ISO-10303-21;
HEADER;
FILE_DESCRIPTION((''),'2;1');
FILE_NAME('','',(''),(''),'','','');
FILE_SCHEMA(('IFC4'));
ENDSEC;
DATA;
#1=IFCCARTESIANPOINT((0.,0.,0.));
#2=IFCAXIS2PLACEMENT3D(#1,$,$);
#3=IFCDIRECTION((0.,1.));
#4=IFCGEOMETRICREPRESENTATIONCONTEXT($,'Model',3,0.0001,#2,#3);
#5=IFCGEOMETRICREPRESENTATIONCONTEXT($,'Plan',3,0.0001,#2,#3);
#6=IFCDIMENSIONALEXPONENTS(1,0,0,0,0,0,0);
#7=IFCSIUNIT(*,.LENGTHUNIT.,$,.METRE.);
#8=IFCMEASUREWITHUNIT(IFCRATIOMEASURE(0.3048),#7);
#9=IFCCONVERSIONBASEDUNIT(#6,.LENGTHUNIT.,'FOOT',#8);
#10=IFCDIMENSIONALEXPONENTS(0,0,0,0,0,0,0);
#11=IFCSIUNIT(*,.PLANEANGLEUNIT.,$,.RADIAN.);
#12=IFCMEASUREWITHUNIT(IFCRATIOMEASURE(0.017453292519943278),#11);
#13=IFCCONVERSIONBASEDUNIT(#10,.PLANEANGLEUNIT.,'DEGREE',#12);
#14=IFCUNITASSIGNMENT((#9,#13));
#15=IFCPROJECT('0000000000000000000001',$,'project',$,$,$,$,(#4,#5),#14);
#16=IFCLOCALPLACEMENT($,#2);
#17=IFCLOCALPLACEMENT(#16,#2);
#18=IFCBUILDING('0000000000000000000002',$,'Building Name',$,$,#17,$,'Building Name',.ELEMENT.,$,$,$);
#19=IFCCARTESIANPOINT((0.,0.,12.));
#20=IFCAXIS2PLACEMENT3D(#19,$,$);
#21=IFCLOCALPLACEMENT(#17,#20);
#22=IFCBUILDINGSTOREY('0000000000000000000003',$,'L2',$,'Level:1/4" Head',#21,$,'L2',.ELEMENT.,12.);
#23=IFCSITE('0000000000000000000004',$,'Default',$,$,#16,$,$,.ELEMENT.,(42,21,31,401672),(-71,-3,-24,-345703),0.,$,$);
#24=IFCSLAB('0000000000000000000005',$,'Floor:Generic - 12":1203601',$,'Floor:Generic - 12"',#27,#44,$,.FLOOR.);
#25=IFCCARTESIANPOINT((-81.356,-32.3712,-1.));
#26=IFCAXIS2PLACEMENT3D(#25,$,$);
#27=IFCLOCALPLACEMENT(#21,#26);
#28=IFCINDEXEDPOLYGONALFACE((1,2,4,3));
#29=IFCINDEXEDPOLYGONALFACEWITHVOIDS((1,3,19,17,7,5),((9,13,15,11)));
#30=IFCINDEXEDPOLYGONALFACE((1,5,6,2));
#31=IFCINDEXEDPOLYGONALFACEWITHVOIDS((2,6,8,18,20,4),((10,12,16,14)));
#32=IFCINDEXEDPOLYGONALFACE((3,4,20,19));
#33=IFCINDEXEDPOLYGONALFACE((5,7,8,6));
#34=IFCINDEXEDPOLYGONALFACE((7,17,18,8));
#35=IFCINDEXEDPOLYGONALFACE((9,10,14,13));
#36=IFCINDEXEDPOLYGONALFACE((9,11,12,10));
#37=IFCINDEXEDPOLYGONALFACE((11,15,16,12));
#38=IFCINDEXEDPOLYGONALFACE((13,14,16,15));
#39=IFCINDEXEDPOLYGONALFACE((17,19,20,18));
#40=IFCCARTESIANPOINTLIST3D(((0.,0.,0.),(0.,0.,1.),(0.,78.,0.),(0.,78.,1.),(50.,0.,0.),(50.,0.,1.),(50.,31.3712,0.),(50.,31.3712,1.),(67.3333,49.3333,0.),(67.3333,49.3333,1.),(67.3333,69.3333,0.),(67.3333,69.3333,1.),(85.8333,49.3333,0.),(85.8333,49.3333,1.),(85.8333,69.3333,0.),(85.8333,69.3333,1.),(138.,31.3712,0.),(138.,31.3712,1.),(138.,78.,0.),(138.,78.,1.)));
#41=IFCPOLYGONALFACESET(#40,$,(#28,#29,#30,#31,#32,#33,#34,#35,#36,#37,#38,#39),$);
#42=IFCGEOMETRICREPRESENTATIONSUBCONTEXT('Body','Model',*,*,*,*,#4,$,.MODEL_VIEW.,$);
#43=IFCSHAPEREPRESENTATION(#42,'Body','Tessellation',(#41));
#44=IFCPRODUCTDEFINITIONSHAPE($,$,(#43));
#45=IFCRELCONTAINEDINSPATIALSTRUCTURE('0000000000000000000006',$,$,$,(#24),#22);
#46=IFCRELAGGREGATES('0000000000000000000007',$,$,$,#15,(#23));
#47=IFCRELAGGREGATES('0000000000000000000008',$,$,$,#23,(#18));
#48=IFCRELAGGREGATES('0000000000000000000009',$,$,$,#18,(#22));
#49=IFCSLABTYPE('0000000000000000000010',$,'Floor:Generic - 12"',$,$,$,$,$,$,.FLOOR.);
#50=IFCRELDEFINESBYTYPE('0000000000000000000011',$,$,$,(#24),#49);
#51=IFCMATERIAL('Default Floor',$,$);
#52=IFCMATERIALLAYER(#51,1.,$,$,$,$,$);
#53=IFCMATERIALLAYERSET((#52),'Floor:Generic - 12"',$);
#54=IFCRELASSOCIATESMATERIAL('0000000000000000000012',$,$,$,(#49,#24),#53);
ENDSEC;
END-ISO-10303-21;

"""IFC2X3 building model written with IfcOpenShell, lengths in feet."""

from ifc_helpers import new_model, entity, si_unit, converted_unit, direction, frame, frame_2d, origin, place, context, subcontext, project, spatial, polyline, rectangle, outline, extrude, material, layer, layer_set, layer_usage, type_object, element, save


model = new_model("IFC2X3")

# Units and contexts
model_context = context("Model", 3, precision=0.0001, world=origin(), true_north=direction((0.0, 1.0)))
plan_context = context("Plan", 3, precision=0.0001, world=origin(), true_north=direction((0.0, 1.0)))
body_context = subcontext(model_context, "Body", "Model", "MODEL_VIEW")
ifc_project = project(units=[converted_unit("LENGTHUNIT", "FOOT", entity("IfcRatioMeasure", 0.3048), si_unit("LENGTHUNIT", "METRE"), dimensions=[1, 0, 0, 0, 0, 0, 0]), converted_unit("PLANEANGLEUNIT", "DEGREE", entity("IfcRatioMeasure", 0.017453292519943278), si_unit("PLANEANGLEUNIT", "RADIAN"), dimensions=[0, 0, 0, 0, 0, 0, 0])], contexts=[model_context, plan_context])

# Site, building, storey
site_placement = place(None, origin())
site = spatial("IfcSite", under=ifc_project, at=site_placement, Name="Default", CompositionType="ELEMENT", RefLatitude=(42, 21, 31, 401672), RefLongitude=(-71, -3, -24, -345703), RefElevation=0.0)
building_placement = place(site_placement, origin())
building = spatial("IfcBuilding", under=site, at=building_placement, Name="Building Name", LongName="Building Name", CompositionType="ELEMENT")
storey_placement = place(building_placement, frame((0.0, 0.0, 12.0)))
storey = spatial("IfcBuildingStorey", under=building, at=storey_placement, Name="L2", ObjectType="Level:1/4\" Head", LongName="L2", CompositionType="ELEMENT", Elevation=12.0)

# Slab, opening
ifc_material_1 = material(Name="Default Floor")
ifc_layer_1 = layer(ifc_material_1, 1.0)
ifc_layer_set_1 = layer_set([ifc_layer_1], Name="Floor:Generic - 12\"")
ifc_layer_usage_1 = layer_usage(ifc_layer_set_1, "AXIS3", "POSITIVE", 0.0)
slab_type_1 = type_object("IfcSlabType", Name="Floor:Generic - 12\"", PredefinedType="FLOOR", material=ifc_layer_set_1)
slab_1_placement = place(storey_placement, frame((-81.356, -32.3712, -1.0)))
slab_1 = element("IfcSlab", 1, at=slab_1_placement, inside=storey, type_object=slab_type_1, material=ifc_layer_usage_1, Name="Floor:Generic - 12\":1203601", ObjectType="Floor:Generic - 12\"", PredefinedType="FLOOR", context=body_context, shape_type="SweptSolid", body=[
    extrude(outline(polyline([(69.0, -39.0), (69.0, 39.0), (-69.0, 39.0), (-69.0, -7.6288), (19.0, -7.6288), (19.0, -39.0), (69.0, -39.0)])), frame((69.0, 39.0, 1.0), z_axis=(0.0, 0.0, -1.0), x_axis=(-1.0, 0.0, 0.0)), (0.0, 0.0, 1.0), 1.0),
])
opening_placement = place(slab_1_placement, origin())
element("IfcOpeningElement", 2, at=opening_placement, cuts=slab_1, ObjectType="Opening", context=body_context, shape_type="SweptSolid", body=[
    extrude(rectangle(XDim=20.0, YDim=18.5, at=frame_2d((0.0, 0.0), x_axis=(1.0, 0.0))), frame((76.5833, 59.3333, 1.0), z_axis=(0.0, 0.0, -1.0), x_axis=(0.0, -1.0, 0.0)), (0.0, 0.0, 1.0), 1.0),
])

save(model, "model.ifc")
